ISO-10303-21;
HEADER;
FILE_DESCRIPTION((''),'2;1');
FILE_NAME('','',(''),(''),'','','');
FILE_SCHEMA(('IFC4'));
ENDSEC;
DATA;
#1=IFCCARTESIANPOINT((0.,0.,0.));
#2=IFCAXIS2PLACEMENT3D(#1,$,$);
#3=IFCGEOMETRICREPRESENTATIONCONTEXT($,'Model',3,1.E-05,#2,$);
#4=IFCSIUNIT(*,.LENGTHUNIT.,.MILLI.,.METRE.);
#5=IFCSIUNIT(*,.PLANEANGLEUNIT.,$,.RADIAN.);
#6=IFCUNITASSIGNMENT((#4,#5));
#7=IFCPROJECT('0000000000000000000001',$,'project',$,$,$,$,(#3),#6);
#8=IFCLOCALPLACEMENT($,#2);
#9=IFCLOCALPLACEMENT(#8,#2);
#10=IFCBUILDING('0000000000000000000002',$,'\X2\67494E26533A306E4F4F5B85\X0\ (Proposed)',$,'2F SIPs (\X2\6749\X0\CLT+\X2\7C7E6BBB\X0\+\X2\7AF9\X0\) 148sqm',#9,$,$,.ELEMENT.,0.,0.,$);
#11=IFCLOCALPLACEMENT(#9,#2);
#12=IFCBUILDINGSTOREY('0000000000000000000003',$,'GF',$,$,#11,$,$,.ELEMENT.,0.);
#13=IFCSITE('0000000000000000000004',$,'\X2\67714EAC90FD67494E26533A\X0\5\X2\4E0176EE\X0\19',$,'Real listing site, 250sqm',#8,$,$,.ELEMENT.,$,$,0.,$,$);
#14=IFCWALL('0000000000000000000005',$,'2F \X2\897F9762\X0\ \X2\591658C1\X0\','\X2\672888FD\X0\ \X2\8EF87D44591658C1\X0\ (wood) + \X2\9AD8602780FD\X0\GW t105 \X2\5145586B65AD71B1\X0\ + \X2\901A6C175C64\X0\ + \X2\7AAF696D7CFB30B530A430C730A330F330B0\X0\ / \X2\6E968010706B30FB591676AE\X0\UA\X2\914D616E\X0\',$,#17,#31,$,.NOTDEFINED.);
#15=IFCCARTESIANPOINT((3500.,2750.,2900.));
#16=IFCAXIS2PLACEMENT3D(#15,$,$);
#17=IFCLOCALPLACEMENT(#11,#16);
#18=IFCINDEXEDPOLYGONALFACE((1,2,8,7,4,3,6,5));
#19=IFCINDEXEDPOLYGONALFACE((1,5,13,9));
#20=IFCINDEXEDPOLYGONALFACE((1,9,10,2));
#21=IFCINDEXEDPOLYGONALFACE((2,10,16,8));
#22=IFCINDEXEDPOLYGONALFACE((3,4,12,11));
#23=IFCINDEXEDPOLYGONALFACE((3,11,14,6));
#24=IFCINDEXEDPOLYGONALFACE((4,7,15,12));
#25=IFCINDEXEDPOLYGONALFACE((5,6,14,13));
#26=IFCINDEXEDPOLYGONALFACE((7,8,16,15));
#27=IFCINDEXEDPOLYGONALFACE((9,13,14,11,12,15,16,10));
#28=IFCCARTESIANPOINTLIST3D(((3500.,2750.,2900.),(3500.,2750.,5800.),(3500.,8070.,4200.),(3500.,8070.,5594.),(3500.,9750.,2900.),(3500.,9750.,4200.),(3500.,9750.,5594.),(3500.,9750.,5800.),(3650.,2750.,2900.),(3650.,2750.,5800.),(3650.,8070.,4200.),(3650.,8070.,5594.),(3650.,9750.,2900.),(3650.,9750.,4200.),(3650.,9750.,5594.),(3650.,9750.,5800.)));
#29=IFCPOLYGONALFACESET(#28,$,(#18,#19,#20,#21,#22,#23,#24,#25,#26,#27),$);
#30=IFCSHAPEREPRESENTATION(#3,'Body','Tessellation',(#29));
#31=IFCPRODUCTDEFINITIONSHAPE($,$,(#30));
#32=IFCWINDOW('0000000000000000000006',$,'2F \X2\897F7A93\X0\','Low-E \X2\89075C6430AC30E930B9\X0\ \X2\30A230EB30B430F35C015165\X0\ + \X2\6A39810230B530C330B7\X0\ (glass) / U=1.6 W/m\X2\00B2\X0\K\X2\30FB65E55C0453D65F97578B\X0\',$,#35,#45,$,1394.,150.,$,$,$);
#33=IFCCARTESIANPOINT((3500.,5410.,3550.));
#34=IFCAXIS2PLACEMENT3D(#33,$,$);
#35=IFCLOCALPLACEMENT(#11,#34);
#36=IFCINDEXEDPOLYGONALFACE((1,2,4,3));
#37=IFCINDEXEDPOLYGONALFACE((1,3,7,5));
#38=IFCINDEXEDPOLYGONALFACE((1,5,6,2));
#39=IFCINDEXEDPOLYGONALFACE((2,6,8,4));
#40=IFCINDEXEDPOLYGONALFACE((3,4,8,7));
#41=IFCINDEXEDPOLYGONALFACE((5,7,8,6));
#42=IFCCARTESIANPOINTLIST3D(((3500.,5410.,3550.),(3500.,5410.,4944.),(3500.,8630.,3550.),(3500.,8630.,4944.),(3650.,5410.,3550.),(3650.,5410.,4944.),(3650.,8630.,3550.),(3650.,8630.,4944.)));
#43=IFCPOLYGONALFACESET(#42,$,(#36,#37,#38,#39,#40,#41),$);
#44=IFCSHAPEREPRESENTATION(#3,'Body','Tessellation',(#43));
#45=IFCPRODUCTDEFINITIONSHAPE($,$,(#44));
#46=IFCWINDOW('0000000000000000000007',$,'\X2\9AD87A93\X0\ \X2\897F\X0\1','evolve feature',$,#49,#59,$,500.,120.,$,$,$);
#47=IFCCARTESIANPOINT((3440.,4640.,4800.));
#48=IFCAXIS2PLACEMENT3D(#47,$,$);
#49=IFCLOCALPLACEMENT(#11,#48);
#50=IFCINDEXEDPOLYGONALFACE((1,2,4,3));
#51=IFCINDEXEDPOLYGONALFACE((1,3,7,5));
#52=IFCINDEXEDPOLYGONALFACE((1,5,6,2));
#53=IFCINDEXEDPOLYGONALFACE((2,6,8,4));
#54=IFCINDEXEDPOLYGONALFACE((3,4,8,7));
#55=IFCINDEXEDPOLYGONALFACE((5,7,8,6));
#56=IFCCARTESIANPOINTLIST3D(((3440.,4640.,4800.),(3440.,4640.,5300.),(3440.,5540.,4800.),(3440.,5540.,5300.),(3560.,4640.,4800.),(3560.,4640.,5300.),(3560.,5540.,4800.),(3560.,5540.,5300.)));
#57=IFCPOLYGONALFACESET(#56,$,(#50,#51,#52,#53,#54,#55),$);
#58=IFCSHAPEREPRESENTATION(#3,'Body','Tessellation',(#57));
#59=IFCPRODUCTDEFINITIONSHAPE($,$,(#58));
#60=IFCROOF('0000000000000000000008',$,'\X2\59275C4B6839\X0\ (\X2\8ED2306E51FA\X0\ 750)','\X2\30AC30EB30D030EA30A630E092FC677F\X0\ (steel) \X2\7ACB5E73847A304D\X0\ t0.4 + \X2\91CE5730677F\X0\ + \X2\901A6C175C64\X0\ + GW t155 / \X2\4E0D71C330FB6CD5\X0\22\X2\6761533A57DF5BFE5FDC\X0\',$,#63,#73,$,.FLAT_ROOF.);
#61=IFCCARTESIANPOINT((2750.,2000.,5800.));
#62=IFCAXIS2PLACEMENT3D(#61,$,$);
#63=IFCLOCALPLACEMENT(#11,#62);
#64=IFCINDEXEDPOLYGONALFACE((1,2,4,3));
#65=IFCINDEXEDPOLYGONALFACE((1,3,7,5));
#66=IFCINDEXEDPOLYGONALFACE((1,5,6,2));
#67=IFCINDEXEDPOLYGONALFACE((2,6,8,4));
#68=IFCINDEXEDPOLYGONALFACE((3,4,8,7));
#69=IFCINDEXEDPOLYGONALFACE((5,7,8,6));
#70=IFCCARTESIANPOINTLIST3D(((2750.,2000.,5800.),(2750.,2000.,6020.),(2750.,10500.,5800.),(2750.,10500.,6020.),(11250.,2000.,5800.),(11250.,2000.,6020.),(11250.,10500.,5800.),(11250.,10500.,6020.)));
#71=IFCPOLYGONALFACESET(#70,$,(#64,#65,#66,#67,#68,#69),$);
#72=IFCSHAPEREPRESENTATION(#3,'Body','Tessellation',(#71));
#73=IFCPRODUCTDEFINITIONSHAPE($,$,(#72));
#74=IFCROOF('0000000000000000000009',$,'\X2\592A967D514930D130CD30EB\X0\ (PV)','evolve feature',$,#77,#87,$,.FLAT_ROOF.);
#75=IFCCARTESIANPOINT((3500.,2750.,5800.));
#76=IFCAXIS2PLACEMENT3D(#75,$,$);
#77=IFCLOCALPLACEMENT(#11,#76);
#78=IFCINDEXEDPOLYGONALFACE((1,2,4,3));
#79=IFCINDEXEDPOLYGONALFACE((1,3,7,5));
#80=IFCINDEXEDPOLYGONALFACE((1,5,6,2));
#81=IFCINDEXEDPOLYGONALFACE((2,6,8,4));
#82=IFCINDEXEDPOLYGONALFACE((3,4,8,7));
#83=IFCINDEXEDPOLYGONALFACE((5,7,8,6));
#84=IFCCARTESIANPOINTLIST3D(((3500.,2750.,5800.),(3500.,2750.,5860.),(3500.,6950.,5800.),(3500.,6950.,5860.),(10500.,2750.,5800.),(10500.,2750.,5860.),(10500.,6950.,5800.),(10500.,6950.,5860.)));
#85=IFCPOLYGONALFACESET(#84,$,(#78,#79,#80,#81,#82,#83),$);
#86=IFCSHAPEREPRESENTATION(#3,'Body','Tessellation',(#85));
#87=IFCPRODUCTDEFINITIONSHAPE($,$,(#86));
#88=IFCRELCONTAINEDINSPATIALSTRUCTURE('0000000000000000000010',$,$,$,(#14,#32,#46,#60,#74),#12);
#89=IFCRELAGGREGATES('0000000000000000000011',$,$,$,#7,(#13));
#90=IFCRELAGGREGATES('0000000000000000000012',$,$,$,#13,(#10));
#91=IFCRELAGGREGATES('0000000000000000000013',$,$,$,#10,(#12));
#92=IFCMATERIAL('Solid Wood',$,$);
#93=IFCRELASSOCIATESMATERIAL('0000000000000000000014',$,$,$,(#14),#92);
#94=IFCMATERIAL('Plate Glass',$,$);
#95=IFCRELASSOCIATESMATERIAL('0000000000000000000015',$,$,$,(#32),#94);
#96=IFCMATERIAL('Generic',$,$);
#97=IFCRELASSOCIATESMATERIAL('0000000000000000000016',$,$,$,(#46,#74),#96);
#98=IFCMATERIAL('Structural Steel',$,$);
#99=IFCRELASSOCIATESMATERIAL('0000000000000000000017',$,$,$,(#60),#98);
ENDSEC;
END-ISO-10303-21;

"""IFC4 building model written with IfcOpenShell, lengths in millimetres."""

from ifc_helpers import new_model, si_unit, frame, frame_2d, origin, place, context, project, spatial, rectangle, extrude, material, element, fill, save


model = new_model("IFC4")

# Units and contexts
model_context = context("Model", 3, precision=1e-05, world=origin())
ifc_project = project(units=[si_unit("LENGTHUNIT", "METRE", prefix="MILLI"), si_unit("PLANEANGLEUNIT", "RADIAN")], contexts=[model_context])

# Site, building, storey
site_placement = place(None, origin())
site = spatial("IfcSite", under=ifc_project, at=site_placement, Name="東京都杉並区5丁目19", ObjectType="Real listing site, 250sqm", CompositionType="ELEMENT", RefElevation=0.0)
building_placement = place(site_placement, origin())
building = spatial("IfcBuilding", under=site, at=building_placement, Name="杉並区の住宅 (Proposed)", ObjectType="2F SIPs (杉CLT+籾殻+竹) 148sqm", CompositionType="ELEMENT", ElevationOfRefHeight=0.0, ElevationOfTerrain=0.0)
storey_placement = place(building_placement, origin())
storey = spatial("IfcBuildingStorey", under=building, at=storey_placement, Name="GF", CompositionType="ELEMENT", Elevation=0.0)

# Shared definitions
ifc_material_1 = material(Name="Solid Wood")
ifc_material_2 = material(Name="Generic")

# Shared definitions
ifc_material_3 = material(Name="Plate Glass")

# Wall, openings, windows
wall_1_placement = place(storey_placement, frame((3500.0, 2750.0, 2900.0)))
wall_1 = element("IfcWall", 1, at=wall_1_placement, inside=storey, material=ifc_material_1, Name="2F 西面 外壁", Description="木製 軸組外壁 (wood) + 高性能GW t105 充填断熱 + 通気層 + 窯業系サイディング / 準耐火・外皮UA配慮", PredefinedType="NOTDEFINED", context=model_context, shape_type="SweptSolid", body=[
    extrude(rectangle(XDim=150.0, YDim=7000.0, at=frame_2d((75.0, 3500.0))), frame((3500.0, 2750.0, 2900.0)), (0.0, 0.0, 1.0), 2900.0),
])
opening_1_placement = place(storey_placement, frame((3500.0, 5410.0, 3550.0)))
opening_1 = element("IfcOpeningElement", 2, at=opening_1_placement, cuts=wall_1, PredefinedType="NOTDEFINED", context=model_context, shape_type="SweptSolid", body=[
    extrude(rectangle(XDim=150.0, YDim=3220.0, at=frame_2d((75.0, 1610.0))), frame((3500.0, 5410.0, 3550.0)), (0.0, 0.0, 1.0), 1394.0),
])
opening_2_placement = place(storey_placement, frame((3440.0, 4640.0, 4800.0)))
opening_2 = element("IfcOpeningElement", 3, at=opening_2_placement, cuts=wall_1, PredefinedType="NOTDEFINED", context=model_context, shape_type="SweptSolid", body=[
    extrude(rectangle(XDim=120.0, YDim=900.0, at=frame_2d((60.0, 450.0))), frame((3440.0, 4640.0, 4800.0)), (0.0, 0.0, 1.0), 500.0),
])
window_1_placement = place(storey_placement, frame((3500.0, 5410.0, 3550.0)))
window_1 = element("IfcWindow", 4, at=window_1_placement, inside=storey, material=ifc_material_3, Name="2F 西窓", Description="Low-E 複層ガラス アルゴン封入 + 樹脂サッシ (glass) / U=1.6 W/m²K・日射取得型", OverallHeight=1394.0, OverallWidth=150.0, context=model_context, shape_type="SweptSolid", body=[
    extrude(rectangle(XDim=150.0, YDim=3220.0, at=frame_2d((75.0, 1610.0))), frame((3500.0, 5410.0, 3550.0)), (0.0, 0.0, 1.0), 1394.0),
])
fill(opening_1, window_1)
window_2_placement = place(storey_placement, frame((3440.0, 4640.0, 4800.0)))
window_2 = element("IfcWindow", 5, at=window_2_placement, inside=storey, material=ifc_material_2, Name="高窓 西1", Description="evolve feature", OverallHeight=500.0, OverallWidth=120.0, context=model_context, shape_type="SweptSolid", body=[
    extrude(rectangle(XDim=120.0, YDim=900.0, at=frame_2d((60.0, 450.0))), frame((3440.0, 4640.0, 4800.0)), (0.0, 0.0, 1.0), 500.0),
])
fill(opening_2, window_2)

# Roofs
ifc_material_4 = material(Name="Structural Steel")
roof_1_placement = place(storey_placement, frame((2750.0, 2000.0, 5800.0)))
element("IfcRoof", 6, at=roof_1_placement, inside=storey, material=ifc_material_4, Name="大屋根 (軒の出 750)", Description="ガルバリウム鋼板 (steel) 立平葺き t0.4 + 野地板 + 通気層 + GW t155 / 不燃・法22条区域対応", PredefinedType="FLAT_ROOF", context=model_context, shape_type="SweptSolid", body=[
    extrude(rectangle(XDim=8500.0, YDim=8500.0, at=frame_2d((4250.0, 4250.0))), frame((2750.0, 2000.0, 5800.0)), (0.0, 0.0, 1.0), 220.0),
])
roof_2_placement = place(storey_placement, frame((3500.0, 2750.0, 5800.0)))
element("IfcRoof", 7, at=roof_2_placement, inside=storey, material=ifc_material_2, Name="太陽光パネル (PV)", Description="evolve feature", PredefinedType="FLAT_ROOF", context=model_context, shape_type="SweptSolid", body=[
    extrude(rectangle(XDim=7000.0, YDim=4200.0, at=frame_2d((3500.0, 2100.0))), frame((3500.0, 2750.0, 5800.0)), (0.0, 0.0, 1.0), 60.0),
])

save(model, "model.ifc")
